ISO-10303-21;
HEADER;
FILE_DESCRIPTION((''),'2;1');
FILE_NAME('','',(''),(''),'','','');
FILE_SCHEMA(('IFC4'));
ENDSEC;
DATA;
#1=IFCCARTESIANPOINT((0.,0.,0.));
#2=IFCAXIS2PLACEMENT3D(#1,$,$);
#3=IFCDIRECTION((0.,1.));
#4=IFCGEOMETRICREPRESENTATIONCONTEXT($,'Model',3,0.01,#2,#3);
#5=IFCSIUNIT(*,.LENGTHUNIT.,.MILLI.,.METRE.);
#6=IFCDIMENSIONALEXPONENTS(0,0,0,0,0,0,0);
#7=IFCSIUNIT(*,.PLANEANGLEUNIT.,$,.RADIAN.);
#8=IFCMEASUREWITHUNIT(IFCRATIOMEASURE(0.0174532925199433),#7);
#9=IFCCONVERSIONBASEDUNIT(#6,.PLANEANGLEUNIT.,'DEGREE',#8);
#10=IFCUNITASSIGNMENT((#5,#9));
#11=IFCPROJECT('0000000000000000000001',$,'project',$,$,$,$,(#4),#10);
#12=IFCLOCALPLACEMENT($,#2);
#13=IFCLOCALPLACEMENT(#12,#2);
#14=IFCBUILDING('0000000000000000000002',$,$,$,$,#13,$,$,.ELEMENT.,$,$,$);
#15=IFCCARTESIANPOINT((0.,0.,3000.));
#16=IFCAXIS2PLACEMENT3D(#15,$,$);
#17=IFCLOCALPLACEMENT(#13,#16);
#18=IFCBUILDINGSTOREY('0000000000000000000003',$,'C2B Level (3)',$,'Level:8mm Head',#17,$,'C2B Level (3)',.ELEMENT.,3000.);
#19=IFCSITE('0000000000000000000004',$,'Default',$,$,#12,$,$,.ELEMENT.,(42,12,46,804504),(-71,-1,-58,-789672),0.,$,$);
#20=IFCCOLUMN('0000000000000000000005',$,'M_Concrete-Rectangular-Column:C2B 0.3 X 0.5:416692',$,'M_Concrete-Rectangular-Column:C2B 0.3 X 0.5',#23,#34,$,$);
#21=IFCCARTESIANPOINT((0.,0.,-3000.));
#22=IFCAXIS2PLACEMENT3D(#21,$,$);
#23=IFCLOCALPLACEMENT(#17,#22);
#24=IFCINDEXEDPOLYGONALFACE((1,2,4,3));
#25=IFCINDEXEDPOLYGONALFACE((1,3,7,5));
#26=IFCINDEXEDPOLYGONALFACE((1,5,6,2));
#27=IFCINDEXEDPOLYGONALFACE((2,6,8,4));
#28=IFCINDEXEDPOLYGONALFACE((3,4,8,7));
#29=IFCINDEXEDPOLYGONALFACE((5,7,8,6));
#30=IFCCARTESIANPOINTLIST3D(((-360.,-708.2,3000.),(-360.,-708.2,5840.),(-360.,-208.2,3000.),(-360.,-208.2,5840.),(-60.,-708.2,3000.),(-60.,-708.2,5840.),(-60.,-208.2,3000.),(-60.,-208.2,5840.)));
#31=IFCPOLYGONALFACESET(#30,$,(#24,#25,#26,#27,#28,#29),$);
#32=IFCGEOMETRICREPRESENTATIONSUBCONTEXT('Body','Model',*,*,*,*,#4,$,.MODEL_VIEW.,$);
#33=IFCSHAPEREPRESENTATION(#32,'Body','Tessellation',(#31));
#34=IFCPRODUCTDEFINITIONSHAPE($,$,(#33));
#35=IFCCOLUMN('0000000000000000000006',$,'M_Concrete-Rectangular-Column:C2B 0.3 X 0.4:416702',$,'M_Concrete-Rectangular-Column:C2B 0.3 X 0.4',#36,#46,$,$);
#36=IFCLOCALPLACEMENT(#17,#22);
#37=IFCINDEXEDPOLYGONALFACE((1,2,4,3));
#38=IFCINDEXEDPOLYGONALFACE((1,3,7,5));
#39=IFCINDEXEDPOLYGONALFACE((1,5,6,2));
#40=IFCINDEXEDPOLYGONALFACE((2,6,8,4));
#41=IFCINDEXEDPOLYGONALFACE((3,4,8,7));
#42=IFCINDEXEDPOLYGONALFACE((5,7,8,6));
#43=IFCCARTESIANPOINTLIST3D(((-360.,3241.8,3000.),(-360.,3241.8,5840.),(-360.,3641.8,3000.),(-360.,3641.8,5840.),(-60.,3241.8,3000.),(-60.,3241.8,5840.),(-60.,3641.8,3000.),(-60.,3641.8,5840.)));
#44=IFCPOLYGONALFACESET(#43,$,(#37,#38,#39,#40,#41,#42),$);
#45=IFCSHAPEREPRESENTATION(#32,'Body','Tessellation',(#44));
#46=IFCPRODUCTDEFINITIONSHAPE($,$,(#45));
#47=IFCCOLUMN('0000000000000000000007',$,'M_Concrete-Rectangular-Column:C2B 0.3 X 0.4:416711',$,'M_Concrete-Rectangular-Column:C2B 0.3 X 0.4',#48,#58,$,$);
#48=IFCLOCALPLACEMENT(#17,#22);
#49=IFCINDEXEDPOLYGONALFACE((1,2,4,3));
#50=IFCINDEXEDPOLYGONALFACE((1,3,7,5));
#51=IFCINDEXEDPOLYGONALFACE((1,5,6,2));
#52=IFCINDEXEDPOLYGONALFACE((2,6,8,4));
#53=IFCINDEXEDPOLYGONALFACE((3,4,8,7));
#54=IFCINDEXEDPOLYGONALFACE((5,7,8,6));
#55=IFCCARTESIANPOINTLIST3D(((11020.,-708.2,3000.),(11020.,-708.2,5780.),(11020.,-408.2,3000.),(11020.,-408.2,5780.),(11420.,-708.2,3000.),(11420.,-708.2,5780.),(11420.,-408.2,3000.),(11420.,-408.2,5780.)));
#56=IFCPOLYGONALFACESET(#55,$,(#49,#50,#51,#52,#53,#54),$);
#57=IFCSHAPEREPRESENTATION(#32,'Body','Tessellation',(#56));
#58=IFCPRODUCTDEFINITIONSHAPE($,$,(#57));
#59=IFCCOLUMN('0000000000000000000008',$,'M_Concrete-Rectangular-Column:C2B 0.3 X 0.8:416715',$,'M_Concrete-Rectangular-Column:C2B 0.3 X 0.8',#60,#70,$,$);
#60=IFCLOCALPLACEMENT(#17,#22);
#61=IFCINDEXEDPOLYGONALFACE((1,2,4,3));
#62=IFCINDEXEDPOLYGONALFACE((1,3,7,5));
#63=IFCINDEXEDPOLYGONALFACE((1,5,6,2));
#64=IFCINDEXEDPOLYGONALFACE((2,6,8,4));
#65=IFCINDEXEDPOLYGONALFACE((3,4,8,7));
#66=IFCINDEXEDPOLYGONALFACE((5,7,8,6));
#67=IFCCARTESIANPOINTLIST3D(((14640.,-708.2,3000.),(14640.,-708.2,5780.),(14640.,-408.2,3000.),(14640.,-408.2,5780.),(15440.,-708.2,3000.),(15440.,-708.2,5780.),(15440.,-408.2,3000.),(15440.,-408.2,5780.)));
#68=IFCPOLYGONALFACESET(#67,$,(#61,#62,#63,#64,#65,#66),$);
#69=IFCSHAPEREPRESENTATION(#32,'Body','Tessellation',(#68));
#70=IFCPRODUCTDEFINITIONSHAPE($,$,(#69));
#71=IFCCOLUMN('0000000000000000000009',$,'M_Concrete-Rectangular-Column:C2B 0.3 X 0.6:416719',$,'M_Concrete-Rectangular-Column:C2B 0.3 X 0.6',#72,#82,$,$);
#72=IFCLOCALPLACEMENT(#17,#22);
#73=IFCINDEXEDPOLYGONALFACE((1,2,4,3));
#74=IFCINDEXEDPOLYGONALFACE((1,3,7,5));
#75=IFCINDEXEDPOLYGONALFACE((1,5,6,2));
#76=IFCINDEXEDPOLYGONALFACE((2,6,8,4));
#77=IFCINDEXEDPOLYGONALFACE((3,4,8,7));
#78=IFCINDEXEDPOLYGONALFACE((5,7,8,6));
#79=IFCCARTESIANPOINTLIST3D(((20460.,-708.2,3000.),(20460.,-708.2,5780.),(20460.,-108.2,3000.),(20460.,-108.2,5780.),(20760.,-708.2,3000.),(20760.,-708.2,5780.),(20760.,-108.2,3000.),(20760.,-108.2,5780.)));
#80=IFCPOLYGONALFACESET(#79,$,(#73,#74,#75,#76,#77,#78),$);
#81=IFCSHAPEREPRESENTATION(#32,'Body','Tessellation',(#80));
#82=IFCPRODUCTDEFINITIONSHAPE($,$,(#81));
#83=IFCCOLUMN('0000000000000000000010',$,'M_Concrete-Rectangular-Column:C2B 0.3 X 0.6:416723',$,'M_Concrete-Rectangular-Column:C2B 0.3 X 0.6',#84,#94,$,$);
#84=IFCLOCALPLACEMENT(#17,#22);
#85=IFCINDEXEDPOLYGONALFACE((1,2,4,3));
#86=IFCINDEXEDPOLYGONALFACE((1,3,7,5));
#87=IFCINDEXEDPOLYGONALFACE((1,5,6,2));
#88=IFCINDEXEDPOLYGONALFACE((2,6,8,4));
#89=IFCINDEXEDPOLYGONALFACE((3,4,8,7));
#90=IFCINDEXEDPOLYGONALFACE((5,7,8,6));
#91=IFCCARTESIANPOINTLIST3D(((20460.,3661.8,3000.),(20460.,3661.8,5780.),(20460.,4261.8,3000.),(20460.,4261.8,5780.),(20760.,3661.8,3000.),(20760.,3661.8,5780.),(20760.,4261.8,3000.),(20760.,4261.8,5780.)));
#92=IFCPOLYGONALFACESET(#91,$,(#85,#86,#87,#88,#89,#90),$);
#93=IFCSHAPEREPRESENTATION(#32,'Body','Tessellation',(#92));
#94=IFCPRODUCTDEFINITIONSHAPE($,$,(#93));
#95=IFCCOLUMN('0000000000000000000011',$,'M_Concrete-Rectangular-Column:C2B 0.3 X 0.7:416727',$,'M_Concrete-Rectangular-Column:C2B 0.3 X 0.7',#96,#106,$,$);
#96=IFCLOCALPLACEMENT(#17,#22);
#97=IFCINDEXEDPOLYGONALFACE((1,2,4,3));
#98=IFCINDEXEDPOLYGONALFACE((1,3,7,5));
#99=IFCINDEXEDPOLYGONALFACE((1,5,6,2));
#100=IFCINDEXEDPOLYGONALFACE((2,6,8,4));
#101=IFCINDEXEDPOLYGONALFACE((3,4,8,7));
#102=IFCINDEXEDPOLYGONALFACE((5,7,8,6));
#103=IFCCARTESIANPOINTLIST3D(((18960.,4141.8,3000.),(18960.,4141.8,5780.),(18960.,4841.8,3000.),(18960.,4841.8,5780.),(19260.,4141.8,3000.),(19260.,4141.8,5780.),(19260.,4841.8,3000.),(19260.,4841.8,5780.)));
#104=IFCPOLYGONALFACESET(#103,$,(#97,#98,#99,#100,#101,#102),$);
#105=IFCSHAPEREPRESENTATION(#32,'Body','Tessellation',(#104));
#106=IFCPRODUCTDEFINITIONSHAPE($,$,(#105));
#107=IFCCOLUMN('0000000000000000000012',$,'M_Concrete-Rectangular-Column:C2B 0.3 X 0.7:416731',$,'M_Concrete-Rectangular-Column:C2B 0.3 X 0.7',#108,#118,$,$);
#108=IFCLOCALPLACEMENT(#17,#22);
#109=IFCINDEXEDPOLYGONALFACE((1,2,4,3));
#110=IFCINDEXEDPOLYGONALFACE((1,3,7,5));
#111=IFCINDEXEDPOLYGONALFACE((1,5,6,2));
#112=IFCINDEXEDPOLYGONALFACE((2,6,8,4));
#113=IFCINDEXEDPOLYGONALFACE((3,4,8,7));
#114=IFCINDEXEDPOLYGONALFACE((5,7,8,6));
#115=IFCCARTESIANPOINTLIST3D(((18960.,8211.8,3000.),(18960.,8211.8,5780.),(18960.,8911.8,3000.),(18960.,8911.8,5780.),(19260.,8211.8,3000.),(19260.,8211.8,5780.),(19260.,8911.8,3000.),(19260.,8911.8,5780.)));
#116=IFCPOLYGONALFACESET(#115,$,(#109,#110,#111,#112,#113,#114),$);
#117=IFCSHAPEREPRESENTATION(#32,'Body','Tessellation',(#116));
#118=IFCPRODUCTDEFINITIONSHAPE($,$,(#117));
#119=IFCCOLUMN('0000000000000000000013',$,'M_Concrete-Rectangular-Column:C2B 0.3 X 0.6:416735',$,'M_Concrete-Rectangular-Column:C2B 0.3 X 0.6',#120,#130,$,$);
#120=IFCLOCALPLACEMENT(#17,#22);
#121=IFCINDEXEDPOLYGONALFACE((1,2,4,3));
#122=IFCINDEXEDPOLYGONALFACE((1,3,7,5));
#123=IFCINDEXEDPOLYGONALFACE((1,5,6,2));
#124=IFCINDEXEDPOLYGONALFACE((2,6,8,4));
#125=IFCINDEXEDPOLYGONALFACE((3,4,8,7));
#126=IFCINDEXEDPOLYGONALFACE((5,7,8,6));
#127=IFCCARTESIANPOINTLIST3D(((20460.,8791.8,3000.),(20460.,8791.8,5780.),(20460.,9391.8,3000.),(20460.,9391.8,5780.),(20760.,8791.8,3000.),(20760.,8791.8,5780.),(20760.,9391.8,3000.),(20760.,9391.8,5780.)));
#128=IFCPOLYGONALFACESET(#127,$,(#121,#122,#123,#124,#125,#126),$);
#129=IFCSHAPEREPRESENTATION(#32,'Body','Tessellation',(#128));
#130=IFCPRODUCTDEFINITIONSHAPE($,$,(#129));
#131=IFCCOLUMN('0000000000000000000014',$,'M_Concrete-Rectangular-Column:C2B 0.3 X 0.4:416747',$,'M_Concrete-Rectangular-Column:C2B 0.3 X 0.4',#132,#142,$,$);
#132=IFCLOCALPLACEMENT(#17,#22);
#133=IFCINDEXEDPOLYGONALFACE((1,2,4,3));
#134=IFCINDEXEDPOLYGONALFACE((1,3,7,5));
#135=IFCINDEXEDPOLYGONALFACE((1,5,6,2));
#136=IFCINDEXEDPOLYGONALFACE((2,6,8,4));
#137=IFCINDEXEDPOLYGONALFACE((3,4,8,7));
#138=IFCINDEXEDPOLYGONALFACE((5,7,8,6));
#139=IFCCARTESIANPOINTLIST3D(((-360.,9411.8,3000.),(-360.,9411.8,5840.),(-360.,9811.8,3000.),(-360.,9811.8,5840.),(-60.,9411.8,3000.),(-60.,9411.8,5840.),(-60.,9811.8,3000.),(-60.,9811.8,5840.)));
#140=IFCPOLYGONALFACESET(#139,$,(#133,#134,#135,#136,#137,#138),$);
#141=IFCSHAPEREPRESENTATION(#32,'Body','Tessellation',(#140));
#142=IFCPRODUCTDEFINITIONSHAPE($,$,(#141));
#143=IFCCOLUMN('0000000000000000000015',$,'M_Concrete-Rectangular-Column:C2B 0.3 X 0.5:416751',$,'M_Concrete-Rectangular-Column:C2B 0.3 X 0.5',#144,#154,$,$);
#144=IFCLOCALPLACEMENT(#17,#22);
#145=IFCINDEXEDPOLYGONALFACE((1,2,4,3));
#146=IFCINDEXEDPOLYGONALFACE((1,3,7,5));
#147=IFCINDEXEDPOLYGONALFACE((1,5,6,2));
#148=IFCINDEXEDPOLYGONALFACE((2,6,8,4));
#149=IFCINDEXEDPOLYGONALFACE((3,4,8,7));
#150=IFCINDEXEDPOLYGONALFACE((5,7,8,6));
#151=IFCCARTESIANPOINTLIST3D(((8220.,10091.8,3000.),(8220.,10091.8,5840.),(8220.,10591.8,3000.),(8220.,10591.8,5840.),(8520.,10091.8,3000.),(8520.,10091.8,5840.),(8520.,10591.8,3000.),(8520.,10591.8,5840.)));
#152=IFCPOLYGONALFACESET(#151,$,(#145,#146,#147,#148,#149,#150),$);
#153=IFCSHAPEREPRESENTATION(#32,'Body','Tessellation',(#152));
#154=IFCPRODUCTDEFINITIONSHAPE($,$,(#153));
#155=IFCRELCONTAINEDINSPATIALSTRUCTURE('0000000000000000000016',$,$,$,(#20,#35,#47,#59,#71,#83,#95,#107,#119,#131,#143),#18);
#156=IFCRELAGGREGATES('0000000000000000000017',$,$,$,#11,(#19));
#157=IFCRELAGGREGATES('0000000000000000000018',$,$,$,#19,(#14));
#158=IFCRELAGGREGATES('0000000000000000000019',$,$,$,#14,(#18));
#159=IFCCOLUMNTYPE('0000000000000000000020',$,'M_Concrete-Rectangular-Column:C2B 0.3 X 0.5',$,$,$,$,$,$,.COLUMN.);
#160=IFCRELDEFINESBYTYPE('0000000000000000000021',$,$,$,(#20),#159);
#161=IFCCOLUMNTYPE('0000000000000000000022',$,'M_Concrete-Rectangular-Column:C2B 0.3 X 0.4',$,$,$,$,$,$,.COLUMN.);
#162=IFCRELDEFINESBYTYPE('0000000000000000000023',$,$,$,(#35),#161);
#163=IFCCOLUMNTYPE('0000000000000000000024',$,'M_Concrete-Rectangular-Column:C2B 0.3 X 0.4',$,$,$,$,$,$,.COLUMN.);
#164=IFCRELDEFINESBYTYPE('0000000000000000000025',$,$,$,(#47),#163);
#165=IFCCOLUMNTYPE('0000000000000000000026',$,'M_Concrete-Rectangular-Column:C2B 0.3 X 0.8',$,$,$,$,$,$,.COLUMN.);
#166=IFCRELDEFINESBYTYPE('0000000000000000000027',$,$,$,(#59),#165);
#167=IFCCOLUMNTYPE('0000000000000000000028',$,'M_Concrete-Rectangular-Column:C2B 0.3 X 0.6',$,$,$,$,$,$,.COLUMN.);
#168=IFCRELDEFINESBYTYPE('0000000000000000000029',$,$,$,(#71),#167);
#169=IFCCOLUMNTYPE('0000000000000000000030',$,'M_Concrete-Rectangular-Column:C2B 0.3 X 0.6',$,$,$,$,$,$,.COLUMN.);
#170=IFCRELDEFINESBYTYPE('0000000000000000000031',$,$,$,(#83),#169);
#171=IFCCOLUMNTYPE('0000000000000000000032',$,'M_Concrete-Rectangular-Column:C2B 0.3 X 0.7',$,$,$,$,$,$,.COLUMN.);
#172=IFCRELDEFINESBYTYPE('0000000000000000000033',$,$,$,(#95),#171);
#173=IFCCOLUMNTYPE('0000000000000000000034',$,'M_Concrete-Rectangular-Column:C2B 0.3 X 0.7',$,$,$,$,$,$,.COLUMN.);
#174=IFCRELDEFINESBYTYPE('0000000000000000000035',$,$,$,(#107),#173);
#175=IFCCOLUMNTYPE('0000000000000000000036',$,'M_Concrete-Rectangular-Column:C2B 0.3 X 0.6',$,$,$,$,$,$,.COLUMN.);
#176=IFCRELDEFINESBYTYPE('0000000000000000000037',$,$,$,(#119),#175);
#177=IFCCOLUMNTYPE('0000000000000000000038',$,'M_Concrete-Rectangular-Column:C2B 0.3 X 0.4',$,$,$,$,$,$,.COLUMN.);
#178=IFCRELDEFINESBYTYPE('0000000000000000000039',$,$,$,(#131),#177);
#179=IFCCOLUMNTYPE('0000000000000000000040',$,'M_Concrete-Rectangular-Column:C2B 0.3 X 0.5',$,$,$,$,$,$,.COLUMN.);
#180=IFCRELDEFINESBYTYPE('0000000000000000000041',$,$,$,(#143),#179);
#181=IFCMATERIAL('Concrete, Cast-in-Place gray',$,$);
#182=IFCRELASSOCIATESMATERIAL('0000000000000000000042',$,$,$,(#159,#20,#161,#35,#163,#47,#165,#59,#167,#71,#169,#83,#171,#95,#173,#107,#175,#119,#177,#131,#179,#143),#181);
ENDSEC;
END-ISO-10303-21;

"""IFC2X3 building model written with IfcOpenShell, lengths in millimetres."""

from ifc_helpers import new_model, entity, si_unit, converted_unit, direction, frame, frame_2d, origin, origin_2d_with_axis, place, context, subcontext, project, spatial, rectangle, extrude, source, transform, mapped, material, type_object, type_shapes, element, save


model = new_model("IFC2X3")

# Units and contexts
model_context = context("Model", 3, precision=0.01, world=origin(), true_north=direction((0.0, 1.0)))
body_context = subcontext(model_context, "Body", "Model", "MODEL_VIEW")
ifc_project = project(units=[si_unit("LENGTHUNIT", "METRE", prefix="MILLI"), converted_unit("PLANEANGLEUNIT", "DEGREE", entity("IfcRatioMeasure", 0.0174532925199433), si_unit("PLANEANGLEUNIT", "RADIAN"), dimensions=[0, 0, 0, 0, 0, 0, 0])], contexts=[model_context])

# Site, building, storey
site_placement = place(None, origin())
site = spatial("IfcSite", under=ifc_project, at=site_placement, Name="Default", CompositionType="ELEMENT", RefLatitude=(42, 12, 46, 804504), RefLongitude=(-71, -1, -58, -789672), RefElevation=0.0)
building_placement = place(site_placement, origin())
building = spatial("IfcBuilding", under=site, at=building_placement, CompositionType="ELEMENT")
storey_placement = place(building_placement, frame((0.0, 0.0, 3000.0)))
storey = spatial("IfcBuildingStorey", under=building, at=storey_placement, Name="C2B Level (3)", ObjectType="Level:8mm Head", LongName="C2B Level (3)", CompositionType="ELEMENT", Elevation=3000.0)

# Columns
ifc_material = material(Name="Concrete, Cast-in-Place gray")
column_type_1 = type_object("IfcColumnType", Name="M_Concrete-Rectangular-Column:C2B 0.3 X 0.5", PredefinedType="COLUMN", material=ifc_material)
shared_shape_1 = source(origin(), body_context, "Body", "SweptSolid", [
    extrude(rectangle(XDim=500.0, YDim=300.0, at=frame_2d((0.0, 0.0), x_axis=(1.0, 0.0))), frame((-210.0, -458.2, 3000.0), z_axis=(0.0, 0.0, 1.0), x_axis=(0.0, -1.0, 0.0)), (0.0, 0.0, 1.0), 2840.0),
])
type_shapes(column_type_1, [shared_shape_1])
column_1_placement = place(storey_placement, frame((0.0, 0.0, -3000.0)))
element("IfcColumn", 1, at=column_1_placement, inside=storey, type_object=column_type_1, material=ifc_material, Name="M_Concrete-Rectangular-Column:C2B 0.3 X 0.5:416692", ObjectType="M_Concrete-Rectangular-Column:C2B 0.3 X 0.5", context=body_context, shape_type="MappedRepresentation", body=[
    mapped(shared_shape_1, transform((0.0, 0.0, 0.0), scale=1.0)),
])
column_type_2 = type_object("IfcColumnType", Name="M_Concrete-Rectangular-Column:C2B 0.3 X 0.4", PredefinedType="COLUMN", material=ifc_material)
shared_shape_2 = source(origin(), body_context, "Body", "SweptSolid", [
    extrude(rectangle(XDim=400.0, YDim=300.0, at=frame_2d((0.0, 0.0), x_axis=(1.0, 0.0))), frame((-210.0, 3441.8, 3000.0), z_axis=(0.0, 0.0, 1.0), x_axis=(0.0, -1.0, 0.0)), (0.0, 0.0, 1.0), 2840.0),
])
type_shapes(column_type_2, [shared_shape_2])
column_2_placement = place(storey_placement, frame((0.0, 0.0, -3000.0)))
element("IfcColumn", 2, at=column_2_placement, inside=storey, type_object=column_type_2, material=ifc_material, Name="M_Concrete-Rectangular-Column:C2B 0.3 X 0.4:416702", ObjectType="M_Concrete-Rectangular-Column:C2B 0.3 X 0.4", context=body_context, shape_type="MappedRepresentation", body=[
    mapped(shared_shape_2, transform((0.0, 0.0, 0.0), scale=1.0)),
])
column_type_3 = type_object("IfcColumnType", Name="M_Concrete-Rectangular-Column:C2B 0.3 X 0.4", PredefinedType="COLUMN", material=ifc_material)
shared_shape_3 = source(origin(), body_context, "Body", "SweptSolid", [
    extrude(rectangle(XDim=300.0, YDim=400.0, at=origin_2d_with_axis()), frame((11220.0, -558.2, 3000.0), z_axis=(0.0, 0.0, 1.0), x_axis=(0.0, -1.0, 0.0)), (0.0, 0.0, 1.0), 2780.0),
])
type_shapes(column_type_3, [shared_shape_3])
column_3_placement = place(storey_placement, frame((0.0, 0.0, -3000.0)))
element("IfcColumn", 3, at=column_3_placement, inside=storey, type_object=column_type_3, material=ifc_material, Name="M_Concrete-Rectangular-Column:C2B 0.3 X 0.4:416711", ObjectType="M_Concrete-Rectangular-Column:C2B 0.3 X 0.4", context=body_context, shape_type="MappedRepresentation", body=[
    mapped(shared_shape_3, transform((0.0, 0.0, 0.0), scale=1.0)),
])
column_type_4 = type_object("IfcColumnType", Name="M_Concrete-Rectangular-Column:C2B 0.3 X 0.8", PredefinedType="COLUMN", material=ifc_material)
shared_shape_4 = source(origin(), body_context, "Body", "SweptSolid", [
    extrude(rectangle(XDim=300.0, YDim=800.0, at=origin_2d_with_axis()), frame((15040.0, -558.2, 3000.0), z_axis=(0.0, 0.0, 1.0), x_axis=(0.0, -1.0, 0.0)), (0.0, 0.0, 1.0), 2780.0),
])
type_shapes(column_type_4, [shared_shape_4])
column_4_placement = place(storey_placement, frame((0.0, 0.0, -3000.0)))
element("IfcColumn", 4, at=column_4_placement, inside=storey, type_object=column_type_4, material=ifc_material, Name="M_Concrete-Rectangular-Column:C2B 0.3 X 0.8:416715", ObjectType="M_Concrete-Rectangular-Column:C2B 0.3 X 0.8", context=body_context, shape_type="MappedRepresentation", body=[
    mapped(shared_shape_4, transform((0.0, 0.0, 0.0), scale=1.0)),
])
column_type_5 = type_object("IfcColumnType", Name="M_Concrete-Rectangular-Column:C2B 0.3 X 0.6", PredefinedType="COLUMN", material=ifc_material)
shared_shape_5 = source(origin(), body_context, "Body", "SweptSolid", [
    extrude(rectangle(XDim=600.0, YDim=300.0, at=frame_2d((0.0, 0.0), x_axis=(1.0, 0.0))), frame((20610.0, -408.2, 3000.0), z_axis=(0.0, 0.0, 1.0), x_axis=(0.0, -1.0, 0.0)), (0.0, 0.0, 1.0), 2780.0),
])
type_shapes(column_type_5, [shared_shape_5])
column_5_placement = place(storey_placement, frame((0.0, 0.0, -3000.0)))
element("IfcColumn", 5, at=column_5_placement, inside=storey, type_object=column_type_5, material=ifc_material, Name="M_Concrete-Rectangular-Column:C2B 0.3 X 0.6:416719", ObjectType="M_Concrete-Rectangular-Column:C2B 0.3 X 0.6", context=body_context, shape_type="MappedRepresentation", body=[
    mapped(shared_shape_5, transform((0.0, 0.0, 0.0), scale=1.0)),
])
column_type_6 = type_object("IfcColumnType", Name="M_Concrete-Rectangular-Column:C2B 0.3 X 0.6", PredefinedType="COLUMN", material=ifc_material)
shared_shape_6 = source(origin(), body_context, "Body", "SweptSolid", [
    extrude(rectangle(XDim=600.0, YDim=300.0, at=origin_2d_with_axis()), frame((20610.0, 3961.8, 3000.0), z_axis=(0.0, 0.0, 1.0), x_axis=(0.0, -1.0, 0.0)), (0.0, 0.0, 1.0), 2780.0),
])
type_shapes(column_type_6, [shared_shape_6])
column_6_placement = place(storey_placement, frame((0.0, 0.0, -3000.0)))
element("IfcColumn", 6, at=column_6_placement, inside=storey, type_object=column_type_6, material=ifc_material, Name="M_Concrete-Rectangular-Column:C2B 0.3 X 0.6:416723", ObjectType="M_Concrete-Rectangular-Column:C2B 0.3 X 0.6", context=body_context, shape_type="MappedRepresentation", body=[
    mapped(shared_shape_6, transform((0.0, 0.0, 0.0), scale=1.0)),
])
column_type_7 = type_object("IfcColumnType", Name="M_Concrete-Rectangular-Column:C2B 0.3 X 0.7", PredefinedType="COLUMN", material=ifc_material)
shared_shape_7 = source(origin(), body_context, "Body", "SweptSolid", [
    extrude(rectangle(XDim=700.0, YDim=300.0, at=origin_2d_with_axis()), frame((19110.0, 4491.8, 3000.0), z_axis=(0.0, 0.0, 1.0), x_axis=(0.0, -1.0, 0.0)), (0.0, 0.0, 1.0), 2780.0),
])
type_shapes(column_type_7, [shared_shape_7])
column_7_placement = place(storey_placement, frame((0.0, 0.0, -3000.0)))
element("IfcColumn", 7, at=column_7_placement, inside=storey, type_object=column_type_7, material=ifc_material, Name="M_Concrete-Rectangular-Column:C2B 0.3 X 0.7:416727", ObjectType="M_Concrete-Rectangular-Column:C2B 0.3 X 0.7", context=body_context, shape_type="MappedRepresentation", body=[
    mapped(shared_shape_7, transform((0.0, 0.0, 0.0), scale=1.0)),
])
column_type_8 = type_object("IfcColumnType", Name="M_Concrete-Rectangular-Column:C2B 0.3 X 0.7", PredefinedType="COLUMN", material=ifc_material)
shared_shape_8 = source(origin(), body_context, "Body", "SweptSolid", [
    extrude(rectangle(XDim=700.0, YDim=300.0, at=origin_2d_with_axis()), frame((19110.0, 8561.8, 3000.0), z_axis=(0.0, 0.0, 1.0), x_axis=(0.0, -1.0, 0.0)), (0.0, 0.0, 1.0), 2780.0),
])
type_shapes(column_type_8, [shared_shape_8])
column_8_placement = place(storey_placement, frame((0.0, 0.0, -3000.0)))
element("IfcColumn", 8, at=column_8_placement, inside=storey, type_object=column_type_8, material=ifc_material, Name="M_Concrete-Rectangular-Column:C2B 0.3 X 0.7:416731", ObjectType="M_Concrete-Rectangular-Column:C2B 0.3 X 0.7", context=body_context, shape_type="MappedRepresentation", body=[
    mapped(shared_shape_8, transform((0.0, 0.0, 0.0), scale=1.0)),
])
column_type_9 = type_object("IfcColumnType", Name="M_Concrete-Rectangular-Column:C2B 0.3 X 0.6", PredefinedType="COLUMN", material=ifc_material)
shared_shape_9 = source(origin(), body_context, "Body", "SweptSolid", [
    extrude(rectangle(XDim=600.0, YDim=300.0, at=origin_2d_with_axis()), frame((20610.0, 9091.8, 3000.0), z_axis=(0.0, 0.0, 1.0), x_axis=(0.0, -1.0, 0.0)), (0.0, 0.0, 1.0), 2780.0),
])
type_shapes(column_type_9, [shared_shape_9])
column_9_placement = place(storey_placement, frame((0.0, 0.0, -3000.0)))
element("IfcColumn", 9, at=column_9_placement, inside=storey, type_object=column_type_9, material=ifc_material, Name="M_Concrete-Rectangular-Column:C2B 0.3 X 0.6:416735", ObjectType="M_Concrete-Rectangular-Column:C2B 0.3 X 0.6", context=body_context, shape_type="MappedRepresentation", body=[
    mapped(shared_shape_9, transform((0.0, 0.0, 0.0), scale=1.0)),
])
column_type_10 = type_object("IfcColumnType", Name="M_Concrete-Rectangular-Column:C2B 0.3 X 0.4", PredefinedType="COLUMN", material=ifc_material)
shared_shape_10 = source(origin(), body_context, "Body", "SweptSolid", [
    extrude(rectangle(XDim=400.0, YDim=300.0, at=frame_2d((0.0, 0.0), x_axis=(1.0, 0.0))), frame((-210.0, 9611.8, 3000.0), z_axis=(0.0, 0.0, 1.0), x_axis=(0.0, -1.0, 0.0)), (0.0, 0.0, 1.0), 2840.0),
])
type_shapes(column_type_10, [shared_shape_10])
column_10_placement = place(storey_placement, frame((0.0, 0.0, -3000.0)))
element("IfcColumn", 10, at=column_10_placement, inside=storey, type_object=column_type_10, material=ifc_material, Name="M_Concrete-Rectangular-Column:C2B 0.3 X 0.4:416747", ObjectType="M_Concrete-Rectangular-Column:C2B 0.3 X 0.4", context=body_context, shape_type="MappedRepresentation", body=[
    mapped(shared_shape_10, transform((0.0, 0.0, 0.0), scale=1.0)),
])
column_type_11 = type_object("IfcColumnType", Name="M_Concrete-Rectangular-Column:C2B 0.3 X 0.5", PredefinedType="COLUMN", material=ifc_material)
shared_shape_11 = source(origin(), body_context, "Body", "SweptSolid", [
    extrude(rectangle(XDim=500.0, YDim=300.0, at=frame_2d((0.0, 0.0), x_axis=(1.0, 0.0))), frame((8370.0, 10341.8, 3000.0), z_axis=(0.0, 0.0, 1.0), x_axis=(0.0, -1.0, 0.0)), (0.0, 0.0, 1.0), 2840.0),
])
type_shapes(column_type_11, [shared_shape_11])
column_11_placement = place(storey_placement, frame((0.0, 0.0, -3000.0)))
element("IfcColumn", 11, at=column_11_placement, inside=storey, type_object=column_type_11, material=ifc_material, Name="M_Concrete-Rectangular-Column:C2B 0.3 X 0.5:416751", ObjectType="M_Concrete-Rectangular-Column:C2B 0.3 X 0.5", context=body_context, shape_type="MappedRepresentation", body=[
    mapped(shared_shape_11, transform((0.0, 0.0, 0.0), scale=1.0)),
])

save(model, "model.ifc")
